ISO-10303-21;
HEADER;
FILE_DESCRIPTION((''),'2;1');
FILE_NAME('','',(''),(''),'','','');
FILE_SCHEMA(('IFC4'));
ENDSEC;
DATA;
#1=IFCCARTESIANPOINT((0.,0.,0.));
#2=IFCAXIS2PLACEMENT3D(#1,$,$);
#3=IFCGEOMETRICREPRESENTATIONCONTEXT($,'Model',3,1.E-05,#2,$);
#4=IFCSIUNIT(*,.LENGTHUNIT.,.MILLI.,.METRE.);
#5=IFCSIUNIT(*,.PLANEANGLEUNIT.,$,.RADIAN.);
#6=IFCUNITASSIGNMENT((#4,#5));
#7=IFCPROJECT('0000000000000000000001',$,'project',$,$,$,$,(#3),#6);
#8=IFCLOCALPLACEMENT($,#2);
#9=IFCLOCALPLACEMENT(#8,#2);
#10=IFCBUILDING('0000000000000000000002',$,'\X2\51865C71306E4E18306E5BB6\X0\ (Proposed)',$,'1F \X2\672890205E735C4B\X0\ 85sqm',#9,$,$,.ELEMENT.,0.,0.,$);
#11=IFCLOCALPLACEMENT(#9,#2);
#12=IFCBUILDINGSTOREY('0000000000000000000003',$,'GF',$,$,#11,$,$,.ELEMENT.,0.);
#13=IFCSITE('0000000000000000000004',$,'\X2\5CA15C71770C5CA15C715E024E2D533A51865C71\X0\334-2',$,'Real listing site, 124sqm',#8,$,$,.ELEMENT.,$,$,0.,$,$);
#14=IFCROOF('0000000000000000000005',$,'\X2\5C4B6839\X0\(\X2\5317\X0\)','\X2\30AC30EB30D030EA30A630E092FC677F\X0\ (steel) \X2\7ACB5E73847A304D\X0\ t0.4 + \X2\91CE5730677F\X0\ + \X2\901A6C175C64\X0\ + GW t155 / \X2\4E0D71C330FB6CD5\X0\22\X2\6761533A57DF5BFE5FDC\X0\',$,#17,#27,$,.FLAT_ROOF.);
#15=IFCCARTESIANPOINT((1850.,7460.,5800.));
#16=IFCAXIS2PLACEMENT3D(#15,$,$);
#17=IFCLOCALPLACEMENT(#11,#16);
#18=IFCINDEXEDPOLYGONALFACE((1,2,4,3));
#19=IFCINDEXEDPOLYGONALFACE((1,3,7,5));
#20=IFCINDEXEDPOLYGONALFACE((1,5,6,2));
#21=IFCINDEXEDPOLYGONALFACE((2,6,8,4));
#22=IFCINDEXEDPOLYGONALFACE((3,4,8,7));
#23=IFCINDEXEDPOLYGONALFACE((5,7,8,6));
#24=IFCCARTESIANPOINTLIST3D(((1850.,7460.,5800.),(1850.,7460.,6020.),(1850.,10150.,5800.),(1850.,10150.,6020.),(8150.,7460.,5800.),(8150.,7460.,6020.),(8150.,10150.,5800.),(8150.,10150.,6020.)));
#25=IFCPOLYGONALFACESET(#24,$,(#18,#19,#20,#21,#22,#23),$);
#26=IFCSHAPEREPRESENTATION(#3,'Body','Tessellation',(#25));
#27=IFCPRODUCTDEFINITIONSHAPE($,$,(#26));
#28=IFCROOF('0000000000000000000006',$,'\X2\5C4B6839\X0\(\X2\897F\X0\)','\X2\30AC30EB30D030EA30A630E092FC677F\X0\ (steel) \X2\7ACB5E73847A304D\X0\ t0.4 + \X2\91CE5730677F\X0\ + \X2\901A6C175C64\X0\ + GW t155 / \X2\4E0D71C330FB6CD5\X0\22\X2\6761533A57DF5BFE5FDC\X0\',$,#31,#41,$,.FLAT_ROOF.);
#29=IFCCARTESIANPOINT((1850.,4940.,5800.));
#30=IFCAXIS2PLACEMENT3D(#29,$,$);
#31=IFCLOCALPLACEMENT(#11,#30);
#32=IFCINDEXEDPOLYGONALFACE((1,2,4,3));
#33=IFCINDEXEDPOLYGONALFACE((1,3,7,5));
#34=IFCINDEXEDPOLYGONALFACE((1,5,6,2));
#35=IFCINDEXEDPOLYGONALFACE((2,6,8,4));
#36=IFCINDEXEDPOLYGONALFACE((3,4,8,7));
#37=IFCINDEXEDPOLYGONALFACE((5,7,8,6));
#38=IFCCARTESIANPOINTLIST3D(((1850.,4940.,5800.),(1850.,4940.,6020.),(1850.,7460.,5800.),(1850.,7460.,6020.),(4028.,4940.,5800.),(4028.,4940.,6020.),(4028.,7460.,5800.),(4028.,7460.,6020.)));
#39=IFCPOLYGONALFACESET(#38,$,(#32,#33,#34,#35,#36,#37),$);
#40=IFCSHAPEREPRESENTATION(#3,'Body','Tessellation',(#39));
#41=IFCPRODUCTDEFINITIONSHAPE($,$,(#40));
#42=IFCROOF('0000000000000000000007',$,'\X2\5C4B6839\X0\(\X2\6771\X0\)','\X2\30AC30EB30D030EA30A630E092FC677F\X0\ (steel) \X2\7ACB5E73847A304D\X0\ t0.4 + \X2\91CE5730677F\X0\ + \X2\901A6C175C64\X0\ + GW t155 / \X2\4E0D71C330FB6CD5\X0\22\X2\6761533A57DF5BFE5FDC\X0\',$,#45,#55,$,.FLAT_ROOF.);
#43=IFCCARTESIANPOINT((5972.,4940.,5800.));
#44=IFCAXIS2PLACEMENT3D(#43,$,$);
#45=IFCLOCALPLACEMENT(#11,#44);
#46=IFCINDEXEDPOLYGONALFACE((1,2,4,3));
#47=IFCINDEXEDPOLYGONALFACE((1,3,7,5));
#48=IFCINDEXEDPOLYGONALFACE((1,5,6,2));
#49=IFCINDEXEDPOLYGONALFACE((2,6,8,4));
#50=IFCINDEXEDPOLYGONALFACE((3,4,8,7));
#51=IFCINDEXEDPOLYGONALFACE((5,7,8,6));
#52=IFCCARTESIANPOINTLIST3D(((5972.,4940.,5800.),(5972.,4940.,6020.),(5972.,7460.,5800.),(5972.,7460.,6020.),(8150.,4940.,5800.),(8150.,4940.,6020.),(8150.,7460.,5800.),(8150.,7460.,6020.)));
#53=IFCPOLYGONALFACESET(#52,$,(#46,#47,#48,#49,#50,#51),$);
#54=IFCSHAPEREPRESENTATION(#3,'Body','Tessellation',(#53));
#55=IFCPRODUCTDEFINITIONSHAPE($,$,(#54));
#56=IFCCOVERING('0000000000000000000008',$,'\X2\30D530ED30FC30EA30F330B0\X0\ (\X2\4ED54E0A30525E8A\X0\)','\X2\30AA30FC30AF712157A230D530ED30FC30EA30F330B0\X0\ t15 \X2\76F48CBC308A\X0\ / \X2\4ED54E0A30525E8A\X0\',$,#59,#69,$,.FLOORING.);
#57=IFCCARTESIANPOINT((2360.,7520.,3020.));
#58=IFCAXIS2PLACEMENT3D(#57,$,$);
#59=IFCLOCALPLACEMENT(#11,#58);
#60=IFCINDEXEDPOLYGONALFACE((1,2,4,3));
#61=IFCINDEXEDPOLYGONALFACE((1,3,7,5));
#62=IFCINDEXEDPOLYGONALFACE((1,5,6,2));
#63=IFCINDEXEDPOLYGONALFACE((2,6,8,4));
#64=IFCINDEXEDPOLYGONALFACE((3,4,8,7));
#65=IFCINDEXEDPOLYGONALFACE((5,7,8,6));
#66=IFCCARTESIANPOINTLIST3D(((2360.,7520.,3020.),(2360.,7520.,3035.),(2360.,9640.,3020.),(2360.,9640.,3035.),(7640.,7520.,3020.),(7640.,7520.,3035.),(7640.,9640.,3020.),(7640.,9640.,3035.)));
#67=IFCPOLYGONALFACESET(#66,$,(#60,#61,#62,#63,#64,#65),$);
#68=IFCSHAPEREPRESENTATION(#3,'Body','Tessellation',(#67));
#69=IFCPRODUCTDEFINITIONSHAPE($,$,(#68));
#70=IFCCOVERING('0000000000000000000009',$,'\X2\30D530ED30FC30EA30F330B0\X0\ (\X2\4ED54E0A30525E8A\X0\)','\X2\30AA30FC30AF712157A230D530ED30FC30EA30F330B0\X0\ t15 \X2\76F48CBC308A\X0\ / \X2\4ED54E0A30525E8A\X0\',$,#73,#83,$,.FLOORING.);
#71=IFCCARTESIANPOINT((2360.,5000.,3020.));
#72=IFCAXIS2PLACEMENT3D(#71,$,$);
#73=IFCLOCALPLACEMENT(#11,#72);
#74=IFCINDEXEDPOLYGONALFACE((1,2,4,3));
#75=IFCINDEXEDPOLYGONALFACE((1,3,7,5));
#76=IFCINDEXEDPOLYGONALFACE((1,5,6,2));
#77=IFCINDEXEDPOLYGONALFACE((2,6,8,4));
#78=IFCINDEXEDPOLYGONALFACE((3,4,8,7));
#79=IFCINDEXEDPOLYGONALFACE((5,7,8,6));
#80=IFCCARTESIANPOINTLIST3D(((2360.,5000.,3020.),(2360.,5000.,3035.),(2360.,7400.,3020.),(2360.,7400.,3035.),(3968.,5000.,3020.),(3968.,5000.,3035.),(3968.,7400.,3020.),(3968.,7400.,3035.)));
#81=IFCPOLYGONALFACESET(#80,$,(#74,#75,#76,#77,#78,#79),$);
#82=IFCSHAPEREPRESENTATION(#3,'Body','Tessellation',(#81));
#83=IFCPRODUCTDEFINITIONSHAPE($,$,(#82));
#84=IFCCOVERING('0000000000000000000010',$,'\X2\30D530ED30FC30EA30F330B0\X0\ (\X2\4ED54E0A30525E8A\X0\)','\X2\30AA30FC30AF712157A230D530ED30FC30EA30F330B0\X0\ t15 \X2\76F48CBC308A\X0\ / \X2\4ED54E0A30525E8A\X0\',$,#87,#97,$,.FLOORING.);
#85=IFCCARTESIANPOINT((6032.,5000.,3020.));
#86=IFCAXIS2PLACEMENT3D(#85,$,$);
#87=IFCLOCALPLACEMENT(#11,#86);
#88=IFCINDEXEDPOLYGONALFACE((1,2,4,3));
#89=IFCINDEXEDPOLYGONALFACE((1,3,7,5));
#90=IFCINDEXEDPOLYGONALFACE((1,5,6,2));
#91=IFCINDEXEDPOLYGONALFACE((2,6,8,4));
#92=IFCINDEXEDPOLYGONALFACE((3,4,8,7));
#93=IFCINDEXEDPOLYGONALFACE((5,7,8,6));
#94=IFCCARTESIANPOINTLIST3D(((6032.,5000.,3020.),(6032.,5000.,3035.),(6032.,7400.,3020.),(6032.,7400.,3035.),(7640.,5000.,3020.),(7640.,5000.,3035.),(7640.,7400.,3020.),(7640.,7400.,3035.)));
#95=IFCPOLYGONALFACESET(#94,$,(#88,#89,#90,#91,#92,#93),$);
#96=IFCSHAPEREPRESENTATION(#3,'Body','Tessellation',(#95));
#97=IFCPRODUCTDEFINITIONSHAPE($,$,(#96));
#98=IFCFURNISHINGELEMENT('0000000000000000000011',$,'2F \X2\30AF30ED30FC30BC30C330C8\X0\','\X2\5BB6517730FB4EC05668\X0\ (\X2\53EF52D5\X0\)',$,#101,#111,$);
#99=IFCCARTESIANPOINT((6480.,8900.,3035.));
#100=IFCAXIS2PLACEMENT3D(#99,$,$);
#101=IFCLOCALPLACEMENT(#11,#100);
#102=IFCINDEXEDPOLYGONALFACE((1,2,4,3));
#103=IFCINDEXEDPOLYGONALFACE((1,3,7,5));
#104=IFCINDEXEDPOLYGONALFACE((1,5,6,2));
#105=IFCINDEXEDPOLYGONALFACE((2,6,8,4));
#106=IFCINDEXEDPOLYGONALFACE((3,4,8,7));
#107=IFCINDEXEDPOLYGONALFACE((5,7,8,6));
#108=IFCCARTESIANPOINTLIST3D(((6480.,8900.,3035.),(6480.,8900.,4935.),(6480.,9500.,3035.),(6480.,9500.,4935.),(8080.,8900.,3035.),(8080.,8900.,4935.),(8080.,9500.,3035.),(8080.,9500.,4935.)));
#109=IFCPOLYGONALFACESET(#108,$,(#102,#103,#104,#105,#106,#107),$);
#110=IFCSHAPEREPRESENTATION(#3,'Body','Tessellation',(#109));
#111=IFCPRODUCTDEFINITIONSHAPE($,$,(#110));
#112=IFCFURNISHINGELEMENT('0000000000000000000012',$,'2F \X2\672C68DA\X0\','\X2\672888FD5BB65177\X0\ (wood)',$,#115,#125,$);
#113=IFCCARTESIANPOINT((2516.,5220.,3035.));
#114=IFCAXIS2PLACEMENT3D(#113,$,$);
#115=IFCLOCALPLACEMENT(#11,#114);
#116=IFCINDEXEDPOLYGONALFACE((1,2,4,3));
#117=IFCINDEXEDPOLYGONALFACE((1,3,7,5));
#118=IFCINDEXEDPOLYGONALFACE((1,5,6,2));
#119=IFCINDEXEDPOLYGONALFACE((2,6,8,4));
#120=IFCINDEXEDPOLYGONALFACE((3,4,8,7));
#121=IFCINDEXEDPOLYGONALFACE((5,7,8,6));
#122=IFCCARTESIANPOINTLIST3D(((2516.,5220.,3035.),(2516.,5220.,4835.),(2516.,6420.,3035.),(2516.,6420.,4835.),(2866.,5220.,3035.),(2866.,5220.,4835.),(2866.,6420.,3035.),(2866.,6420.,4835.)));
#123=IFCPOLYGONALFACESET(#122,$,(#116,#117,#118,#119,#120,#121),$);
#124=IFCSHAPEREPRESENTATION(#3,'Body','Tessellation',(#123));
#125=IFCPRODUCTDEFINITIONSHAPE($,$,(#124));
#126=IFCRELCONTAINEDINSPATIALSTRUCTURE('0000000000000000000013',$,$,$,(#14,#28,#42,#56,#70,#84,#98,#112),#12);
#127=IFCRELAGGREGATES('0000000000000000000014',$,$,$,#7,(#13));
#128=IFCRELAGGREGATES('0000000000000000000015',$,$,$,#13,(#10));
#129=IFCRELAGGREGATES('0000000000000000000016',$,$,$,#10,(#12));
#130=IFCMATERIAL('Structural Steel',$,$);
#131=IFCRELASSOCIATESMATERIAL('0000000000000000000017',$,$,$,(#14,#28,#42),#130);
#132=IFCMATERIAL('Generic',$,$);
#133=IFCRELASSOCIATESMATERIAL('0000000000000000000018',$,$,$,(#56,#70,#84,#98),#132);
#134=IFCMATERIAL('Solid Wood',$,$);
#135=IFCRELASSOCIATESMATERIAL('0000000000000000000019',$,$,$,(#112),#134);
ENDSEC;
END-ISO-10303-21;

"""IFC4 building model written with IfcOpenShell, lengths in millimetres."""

from ifc_helpers import new_model, si_unit, frame, frame_2d, origin, place, context, project, spatial, rectangle, extrude, material, element, save


model = new_model("IFC4")

# Units and contexts
model_context = context("Model", 3, precision=1e-05, world=origin())
ifc_project = project(units=[si_unit("LENGTHUNIT", "METRE", prefix="MILLI"), si_unit("PLANEANGLEUNIT", "RADIAN")], contexts=[model_context])

# Site, building, storey
site_placement = place(None, origin())
site = spatial("IfcSite", under=ifc_project, at=site_placement, Name="岡山県岡山市中区円山334-2", ObjectType="Real listing site, 124sqm", CompositionType="ELEMENT", RefElevation=0.0)
building_placement = place(site_placement, origin())
building = spatial("IfcBuilding", under=site, at=building_placement, Name="円山の丘の家 (Proposed)", ObjectType="1F 木造平屋 85sqm", CompositionType="ELEMENT", ElevationOfRefHeight=0.0, ElevationOfTerrain=0.0)
storey_placement = place(building_placement, origin())
storey = spatial("IfcBuildingStorey", under=building, at=storey_placement, Name="GF", CompositionType="ELEMENT", Elevation=0.0)

# Shared definitions
ifc_material_1 = material(Name="Solid Wood")

# Shared definitions
ifc_material_2 = material(Name="Generic")

# Roofs
ifc_material_3 = material(Name="Structural Steel")
for number, where, name in (
    (1, (1850.0, 7460.0, 5800.0), "屋根(北)"),
):
    element("IfcRoof", number, at=place(storey_placement, frame(where)), inside=storey, material=ifc_material_3, Name=name, Description="ガルバリウム鋼板 (steel) 立平葺き t0.4 + 野地板 + 通気層 + GW t155 / 不燃・法22条区域対応", PredefinedType="FLAT_ROOF", context=model_context, shape_type="SweptSolid", body=[
        extrude(rectangle(XDim=6300.0, YDim=2690.0, at=frame_2d((3150.0, 1345.0))), frame((1850.0, 7460.0, 5800.0)), (0.0, 0.0, 1.0), 220.0),
    ])
roof_1_placement = place(storey_placement, frame((1850.0, 4940.0, 5800.0)))
element("IfcRoof", 2, at=roof_1_placement, inside=storey, material=ifc_material_3, Name="屋根(西)", Description="ガルバリウム鋼板 (steel) 立平葺き t0.4 + 野地板 + 通気層 + GW t155 / 不燃・法22条区域対応", PredefinedType="FLAT_ROOF", context=model_context, shape_type="SweptSolid", body=[
    extrude(rectangle(XDim=2178.0, YDim=2520.0, at=frame_2d((1089.0, 1260.0))), frame((1850.0, 4940.0, 5800.0)), (0.0, 0.0, 1.0), 220.0),
])
roof_2_placement = place(storey_placement, frame((5972.0, 4940.0, 5800.0)))
element("IfcRoof", 3, at=roof_2_placement, inside=storey, material=ifc_material_3, Name="屋根(東)", Description="ガルバリウム鋼板 (steel) 立平葺き t0.4 + 野地板 + 通気層 + GW t155 / 不燃・法22条区域対応", PredefinedType="FLAT_ROOF", context=model_context, shape_type="SweptSolid", body=[
    extrude(rectangle(XDim=2178.0, YDim=2520.0, at=frame_2d((1089.0, 1260.0))), frame((5972.0, 4940.0, 5800.0)), (0.0, 0.0, 1.0), 220.0),
])

# Coverings
covering_1_placement = place(storey_placement, frame((2360.0, 7520.0, 3020.0)))
element("IfcCovering", 4, at=covering_1_placement, inside=storey, material=ifc_material_2, Name="フローリング (仕上げ床)", Description="オーク無垢フローリング t15 直貼り / 仕上げ床", PredefinedType="FLOORING", context=model_context, shape_type="SweptSolid", body=[
    extrude(rectangle(XDim=5280.0, YDim=2120.0, at=frame_2d((2640.0, 1060.0))), frame((2360.0, 7520.0, 3020.0)), (0.0, 0.0, 1.0), 15.0),
])
covering_2_placement = place(storey_placement, frame((2360.0, 5000.0, 3020.0)))
element("IfcCovering", 5, at=covering_2_placement, inside=storey, material=ifc_material_2, Name="フローリング (仕上げ床)", Description="オーク無垢フローリング t15 直貼り / 仕上げ床", PredefinedType="FLOORING", context=model_context, shape_type="SweptSolid", body=[
    extrude(rectangle(XDim=1608.0, YDim=2400.0, at=frame_2d((804.0, 1200.0))), frame((2360.0, 5000.0, 3020.0)), (0.0, 0.0, 1.0), 15.0),
])
covering_3_placement = place(storey_placement, frame((6032.0, 5000.0, 3020.0)))
element("IfcCovering", 6, at=covering_3_placement, inside=storey, material=ifc_material_2, Name="フローリング (仕上げ床)", Description="オーク無垢フローリング t15 直貼り / 仕上げ床", PredefinedType="FLOORING", context=model_context, shape_type="SweptSolid", body=[
    extrude(rectangle(XDim=1608.0, YDim=2400.0, at=frame_2d((804.0, 1200.0))), frame((6032.0, 5000.0, 3020.0)), (0.0, 0.0, 1.0), 15.0),
])

# Furnishing elements
furnishing_1_placement = place(storey_placement, frame((6480.0, 8900.0, 3035.0)))
element("IfcFurnishingElement", 7, at=furnishing_1_placement, inside=storey, material=ifc_material_2, Name="2F クローゼット", Description="家具・什器 (可動)", context=model_context, shape_type="SweptSolid", body=[
    extrude(rectangle(XDim=1600.0, YDim=600.0, at=frame_2d((800.0, 300.0))), frame((6480.0, 8900.0, 3035.0)), (0.0, 0.0, 1.0), 1900.0),
])
furnishing_2_placement = place(storey_placement, frame((2516.0, 5220.0, 3035.0)))
element("IfcFurnishingElement", 8, at=furnishing_2_placement, inside=storey, material=ifc_material_1, Name="2F 本棚", Description="木製家具 (wood)", context=model_context, shape_type="SweptSolid", body=[
    extrude(rectangle(XDim=350.0, YDim=1200.0, at=frame_2d((175.0, 600.0))), frame((2516.0, 5220.0, 3035.0)), (0.0, 0.0, 1.0), 1800.0),
])

save(model, "model.ifc")
